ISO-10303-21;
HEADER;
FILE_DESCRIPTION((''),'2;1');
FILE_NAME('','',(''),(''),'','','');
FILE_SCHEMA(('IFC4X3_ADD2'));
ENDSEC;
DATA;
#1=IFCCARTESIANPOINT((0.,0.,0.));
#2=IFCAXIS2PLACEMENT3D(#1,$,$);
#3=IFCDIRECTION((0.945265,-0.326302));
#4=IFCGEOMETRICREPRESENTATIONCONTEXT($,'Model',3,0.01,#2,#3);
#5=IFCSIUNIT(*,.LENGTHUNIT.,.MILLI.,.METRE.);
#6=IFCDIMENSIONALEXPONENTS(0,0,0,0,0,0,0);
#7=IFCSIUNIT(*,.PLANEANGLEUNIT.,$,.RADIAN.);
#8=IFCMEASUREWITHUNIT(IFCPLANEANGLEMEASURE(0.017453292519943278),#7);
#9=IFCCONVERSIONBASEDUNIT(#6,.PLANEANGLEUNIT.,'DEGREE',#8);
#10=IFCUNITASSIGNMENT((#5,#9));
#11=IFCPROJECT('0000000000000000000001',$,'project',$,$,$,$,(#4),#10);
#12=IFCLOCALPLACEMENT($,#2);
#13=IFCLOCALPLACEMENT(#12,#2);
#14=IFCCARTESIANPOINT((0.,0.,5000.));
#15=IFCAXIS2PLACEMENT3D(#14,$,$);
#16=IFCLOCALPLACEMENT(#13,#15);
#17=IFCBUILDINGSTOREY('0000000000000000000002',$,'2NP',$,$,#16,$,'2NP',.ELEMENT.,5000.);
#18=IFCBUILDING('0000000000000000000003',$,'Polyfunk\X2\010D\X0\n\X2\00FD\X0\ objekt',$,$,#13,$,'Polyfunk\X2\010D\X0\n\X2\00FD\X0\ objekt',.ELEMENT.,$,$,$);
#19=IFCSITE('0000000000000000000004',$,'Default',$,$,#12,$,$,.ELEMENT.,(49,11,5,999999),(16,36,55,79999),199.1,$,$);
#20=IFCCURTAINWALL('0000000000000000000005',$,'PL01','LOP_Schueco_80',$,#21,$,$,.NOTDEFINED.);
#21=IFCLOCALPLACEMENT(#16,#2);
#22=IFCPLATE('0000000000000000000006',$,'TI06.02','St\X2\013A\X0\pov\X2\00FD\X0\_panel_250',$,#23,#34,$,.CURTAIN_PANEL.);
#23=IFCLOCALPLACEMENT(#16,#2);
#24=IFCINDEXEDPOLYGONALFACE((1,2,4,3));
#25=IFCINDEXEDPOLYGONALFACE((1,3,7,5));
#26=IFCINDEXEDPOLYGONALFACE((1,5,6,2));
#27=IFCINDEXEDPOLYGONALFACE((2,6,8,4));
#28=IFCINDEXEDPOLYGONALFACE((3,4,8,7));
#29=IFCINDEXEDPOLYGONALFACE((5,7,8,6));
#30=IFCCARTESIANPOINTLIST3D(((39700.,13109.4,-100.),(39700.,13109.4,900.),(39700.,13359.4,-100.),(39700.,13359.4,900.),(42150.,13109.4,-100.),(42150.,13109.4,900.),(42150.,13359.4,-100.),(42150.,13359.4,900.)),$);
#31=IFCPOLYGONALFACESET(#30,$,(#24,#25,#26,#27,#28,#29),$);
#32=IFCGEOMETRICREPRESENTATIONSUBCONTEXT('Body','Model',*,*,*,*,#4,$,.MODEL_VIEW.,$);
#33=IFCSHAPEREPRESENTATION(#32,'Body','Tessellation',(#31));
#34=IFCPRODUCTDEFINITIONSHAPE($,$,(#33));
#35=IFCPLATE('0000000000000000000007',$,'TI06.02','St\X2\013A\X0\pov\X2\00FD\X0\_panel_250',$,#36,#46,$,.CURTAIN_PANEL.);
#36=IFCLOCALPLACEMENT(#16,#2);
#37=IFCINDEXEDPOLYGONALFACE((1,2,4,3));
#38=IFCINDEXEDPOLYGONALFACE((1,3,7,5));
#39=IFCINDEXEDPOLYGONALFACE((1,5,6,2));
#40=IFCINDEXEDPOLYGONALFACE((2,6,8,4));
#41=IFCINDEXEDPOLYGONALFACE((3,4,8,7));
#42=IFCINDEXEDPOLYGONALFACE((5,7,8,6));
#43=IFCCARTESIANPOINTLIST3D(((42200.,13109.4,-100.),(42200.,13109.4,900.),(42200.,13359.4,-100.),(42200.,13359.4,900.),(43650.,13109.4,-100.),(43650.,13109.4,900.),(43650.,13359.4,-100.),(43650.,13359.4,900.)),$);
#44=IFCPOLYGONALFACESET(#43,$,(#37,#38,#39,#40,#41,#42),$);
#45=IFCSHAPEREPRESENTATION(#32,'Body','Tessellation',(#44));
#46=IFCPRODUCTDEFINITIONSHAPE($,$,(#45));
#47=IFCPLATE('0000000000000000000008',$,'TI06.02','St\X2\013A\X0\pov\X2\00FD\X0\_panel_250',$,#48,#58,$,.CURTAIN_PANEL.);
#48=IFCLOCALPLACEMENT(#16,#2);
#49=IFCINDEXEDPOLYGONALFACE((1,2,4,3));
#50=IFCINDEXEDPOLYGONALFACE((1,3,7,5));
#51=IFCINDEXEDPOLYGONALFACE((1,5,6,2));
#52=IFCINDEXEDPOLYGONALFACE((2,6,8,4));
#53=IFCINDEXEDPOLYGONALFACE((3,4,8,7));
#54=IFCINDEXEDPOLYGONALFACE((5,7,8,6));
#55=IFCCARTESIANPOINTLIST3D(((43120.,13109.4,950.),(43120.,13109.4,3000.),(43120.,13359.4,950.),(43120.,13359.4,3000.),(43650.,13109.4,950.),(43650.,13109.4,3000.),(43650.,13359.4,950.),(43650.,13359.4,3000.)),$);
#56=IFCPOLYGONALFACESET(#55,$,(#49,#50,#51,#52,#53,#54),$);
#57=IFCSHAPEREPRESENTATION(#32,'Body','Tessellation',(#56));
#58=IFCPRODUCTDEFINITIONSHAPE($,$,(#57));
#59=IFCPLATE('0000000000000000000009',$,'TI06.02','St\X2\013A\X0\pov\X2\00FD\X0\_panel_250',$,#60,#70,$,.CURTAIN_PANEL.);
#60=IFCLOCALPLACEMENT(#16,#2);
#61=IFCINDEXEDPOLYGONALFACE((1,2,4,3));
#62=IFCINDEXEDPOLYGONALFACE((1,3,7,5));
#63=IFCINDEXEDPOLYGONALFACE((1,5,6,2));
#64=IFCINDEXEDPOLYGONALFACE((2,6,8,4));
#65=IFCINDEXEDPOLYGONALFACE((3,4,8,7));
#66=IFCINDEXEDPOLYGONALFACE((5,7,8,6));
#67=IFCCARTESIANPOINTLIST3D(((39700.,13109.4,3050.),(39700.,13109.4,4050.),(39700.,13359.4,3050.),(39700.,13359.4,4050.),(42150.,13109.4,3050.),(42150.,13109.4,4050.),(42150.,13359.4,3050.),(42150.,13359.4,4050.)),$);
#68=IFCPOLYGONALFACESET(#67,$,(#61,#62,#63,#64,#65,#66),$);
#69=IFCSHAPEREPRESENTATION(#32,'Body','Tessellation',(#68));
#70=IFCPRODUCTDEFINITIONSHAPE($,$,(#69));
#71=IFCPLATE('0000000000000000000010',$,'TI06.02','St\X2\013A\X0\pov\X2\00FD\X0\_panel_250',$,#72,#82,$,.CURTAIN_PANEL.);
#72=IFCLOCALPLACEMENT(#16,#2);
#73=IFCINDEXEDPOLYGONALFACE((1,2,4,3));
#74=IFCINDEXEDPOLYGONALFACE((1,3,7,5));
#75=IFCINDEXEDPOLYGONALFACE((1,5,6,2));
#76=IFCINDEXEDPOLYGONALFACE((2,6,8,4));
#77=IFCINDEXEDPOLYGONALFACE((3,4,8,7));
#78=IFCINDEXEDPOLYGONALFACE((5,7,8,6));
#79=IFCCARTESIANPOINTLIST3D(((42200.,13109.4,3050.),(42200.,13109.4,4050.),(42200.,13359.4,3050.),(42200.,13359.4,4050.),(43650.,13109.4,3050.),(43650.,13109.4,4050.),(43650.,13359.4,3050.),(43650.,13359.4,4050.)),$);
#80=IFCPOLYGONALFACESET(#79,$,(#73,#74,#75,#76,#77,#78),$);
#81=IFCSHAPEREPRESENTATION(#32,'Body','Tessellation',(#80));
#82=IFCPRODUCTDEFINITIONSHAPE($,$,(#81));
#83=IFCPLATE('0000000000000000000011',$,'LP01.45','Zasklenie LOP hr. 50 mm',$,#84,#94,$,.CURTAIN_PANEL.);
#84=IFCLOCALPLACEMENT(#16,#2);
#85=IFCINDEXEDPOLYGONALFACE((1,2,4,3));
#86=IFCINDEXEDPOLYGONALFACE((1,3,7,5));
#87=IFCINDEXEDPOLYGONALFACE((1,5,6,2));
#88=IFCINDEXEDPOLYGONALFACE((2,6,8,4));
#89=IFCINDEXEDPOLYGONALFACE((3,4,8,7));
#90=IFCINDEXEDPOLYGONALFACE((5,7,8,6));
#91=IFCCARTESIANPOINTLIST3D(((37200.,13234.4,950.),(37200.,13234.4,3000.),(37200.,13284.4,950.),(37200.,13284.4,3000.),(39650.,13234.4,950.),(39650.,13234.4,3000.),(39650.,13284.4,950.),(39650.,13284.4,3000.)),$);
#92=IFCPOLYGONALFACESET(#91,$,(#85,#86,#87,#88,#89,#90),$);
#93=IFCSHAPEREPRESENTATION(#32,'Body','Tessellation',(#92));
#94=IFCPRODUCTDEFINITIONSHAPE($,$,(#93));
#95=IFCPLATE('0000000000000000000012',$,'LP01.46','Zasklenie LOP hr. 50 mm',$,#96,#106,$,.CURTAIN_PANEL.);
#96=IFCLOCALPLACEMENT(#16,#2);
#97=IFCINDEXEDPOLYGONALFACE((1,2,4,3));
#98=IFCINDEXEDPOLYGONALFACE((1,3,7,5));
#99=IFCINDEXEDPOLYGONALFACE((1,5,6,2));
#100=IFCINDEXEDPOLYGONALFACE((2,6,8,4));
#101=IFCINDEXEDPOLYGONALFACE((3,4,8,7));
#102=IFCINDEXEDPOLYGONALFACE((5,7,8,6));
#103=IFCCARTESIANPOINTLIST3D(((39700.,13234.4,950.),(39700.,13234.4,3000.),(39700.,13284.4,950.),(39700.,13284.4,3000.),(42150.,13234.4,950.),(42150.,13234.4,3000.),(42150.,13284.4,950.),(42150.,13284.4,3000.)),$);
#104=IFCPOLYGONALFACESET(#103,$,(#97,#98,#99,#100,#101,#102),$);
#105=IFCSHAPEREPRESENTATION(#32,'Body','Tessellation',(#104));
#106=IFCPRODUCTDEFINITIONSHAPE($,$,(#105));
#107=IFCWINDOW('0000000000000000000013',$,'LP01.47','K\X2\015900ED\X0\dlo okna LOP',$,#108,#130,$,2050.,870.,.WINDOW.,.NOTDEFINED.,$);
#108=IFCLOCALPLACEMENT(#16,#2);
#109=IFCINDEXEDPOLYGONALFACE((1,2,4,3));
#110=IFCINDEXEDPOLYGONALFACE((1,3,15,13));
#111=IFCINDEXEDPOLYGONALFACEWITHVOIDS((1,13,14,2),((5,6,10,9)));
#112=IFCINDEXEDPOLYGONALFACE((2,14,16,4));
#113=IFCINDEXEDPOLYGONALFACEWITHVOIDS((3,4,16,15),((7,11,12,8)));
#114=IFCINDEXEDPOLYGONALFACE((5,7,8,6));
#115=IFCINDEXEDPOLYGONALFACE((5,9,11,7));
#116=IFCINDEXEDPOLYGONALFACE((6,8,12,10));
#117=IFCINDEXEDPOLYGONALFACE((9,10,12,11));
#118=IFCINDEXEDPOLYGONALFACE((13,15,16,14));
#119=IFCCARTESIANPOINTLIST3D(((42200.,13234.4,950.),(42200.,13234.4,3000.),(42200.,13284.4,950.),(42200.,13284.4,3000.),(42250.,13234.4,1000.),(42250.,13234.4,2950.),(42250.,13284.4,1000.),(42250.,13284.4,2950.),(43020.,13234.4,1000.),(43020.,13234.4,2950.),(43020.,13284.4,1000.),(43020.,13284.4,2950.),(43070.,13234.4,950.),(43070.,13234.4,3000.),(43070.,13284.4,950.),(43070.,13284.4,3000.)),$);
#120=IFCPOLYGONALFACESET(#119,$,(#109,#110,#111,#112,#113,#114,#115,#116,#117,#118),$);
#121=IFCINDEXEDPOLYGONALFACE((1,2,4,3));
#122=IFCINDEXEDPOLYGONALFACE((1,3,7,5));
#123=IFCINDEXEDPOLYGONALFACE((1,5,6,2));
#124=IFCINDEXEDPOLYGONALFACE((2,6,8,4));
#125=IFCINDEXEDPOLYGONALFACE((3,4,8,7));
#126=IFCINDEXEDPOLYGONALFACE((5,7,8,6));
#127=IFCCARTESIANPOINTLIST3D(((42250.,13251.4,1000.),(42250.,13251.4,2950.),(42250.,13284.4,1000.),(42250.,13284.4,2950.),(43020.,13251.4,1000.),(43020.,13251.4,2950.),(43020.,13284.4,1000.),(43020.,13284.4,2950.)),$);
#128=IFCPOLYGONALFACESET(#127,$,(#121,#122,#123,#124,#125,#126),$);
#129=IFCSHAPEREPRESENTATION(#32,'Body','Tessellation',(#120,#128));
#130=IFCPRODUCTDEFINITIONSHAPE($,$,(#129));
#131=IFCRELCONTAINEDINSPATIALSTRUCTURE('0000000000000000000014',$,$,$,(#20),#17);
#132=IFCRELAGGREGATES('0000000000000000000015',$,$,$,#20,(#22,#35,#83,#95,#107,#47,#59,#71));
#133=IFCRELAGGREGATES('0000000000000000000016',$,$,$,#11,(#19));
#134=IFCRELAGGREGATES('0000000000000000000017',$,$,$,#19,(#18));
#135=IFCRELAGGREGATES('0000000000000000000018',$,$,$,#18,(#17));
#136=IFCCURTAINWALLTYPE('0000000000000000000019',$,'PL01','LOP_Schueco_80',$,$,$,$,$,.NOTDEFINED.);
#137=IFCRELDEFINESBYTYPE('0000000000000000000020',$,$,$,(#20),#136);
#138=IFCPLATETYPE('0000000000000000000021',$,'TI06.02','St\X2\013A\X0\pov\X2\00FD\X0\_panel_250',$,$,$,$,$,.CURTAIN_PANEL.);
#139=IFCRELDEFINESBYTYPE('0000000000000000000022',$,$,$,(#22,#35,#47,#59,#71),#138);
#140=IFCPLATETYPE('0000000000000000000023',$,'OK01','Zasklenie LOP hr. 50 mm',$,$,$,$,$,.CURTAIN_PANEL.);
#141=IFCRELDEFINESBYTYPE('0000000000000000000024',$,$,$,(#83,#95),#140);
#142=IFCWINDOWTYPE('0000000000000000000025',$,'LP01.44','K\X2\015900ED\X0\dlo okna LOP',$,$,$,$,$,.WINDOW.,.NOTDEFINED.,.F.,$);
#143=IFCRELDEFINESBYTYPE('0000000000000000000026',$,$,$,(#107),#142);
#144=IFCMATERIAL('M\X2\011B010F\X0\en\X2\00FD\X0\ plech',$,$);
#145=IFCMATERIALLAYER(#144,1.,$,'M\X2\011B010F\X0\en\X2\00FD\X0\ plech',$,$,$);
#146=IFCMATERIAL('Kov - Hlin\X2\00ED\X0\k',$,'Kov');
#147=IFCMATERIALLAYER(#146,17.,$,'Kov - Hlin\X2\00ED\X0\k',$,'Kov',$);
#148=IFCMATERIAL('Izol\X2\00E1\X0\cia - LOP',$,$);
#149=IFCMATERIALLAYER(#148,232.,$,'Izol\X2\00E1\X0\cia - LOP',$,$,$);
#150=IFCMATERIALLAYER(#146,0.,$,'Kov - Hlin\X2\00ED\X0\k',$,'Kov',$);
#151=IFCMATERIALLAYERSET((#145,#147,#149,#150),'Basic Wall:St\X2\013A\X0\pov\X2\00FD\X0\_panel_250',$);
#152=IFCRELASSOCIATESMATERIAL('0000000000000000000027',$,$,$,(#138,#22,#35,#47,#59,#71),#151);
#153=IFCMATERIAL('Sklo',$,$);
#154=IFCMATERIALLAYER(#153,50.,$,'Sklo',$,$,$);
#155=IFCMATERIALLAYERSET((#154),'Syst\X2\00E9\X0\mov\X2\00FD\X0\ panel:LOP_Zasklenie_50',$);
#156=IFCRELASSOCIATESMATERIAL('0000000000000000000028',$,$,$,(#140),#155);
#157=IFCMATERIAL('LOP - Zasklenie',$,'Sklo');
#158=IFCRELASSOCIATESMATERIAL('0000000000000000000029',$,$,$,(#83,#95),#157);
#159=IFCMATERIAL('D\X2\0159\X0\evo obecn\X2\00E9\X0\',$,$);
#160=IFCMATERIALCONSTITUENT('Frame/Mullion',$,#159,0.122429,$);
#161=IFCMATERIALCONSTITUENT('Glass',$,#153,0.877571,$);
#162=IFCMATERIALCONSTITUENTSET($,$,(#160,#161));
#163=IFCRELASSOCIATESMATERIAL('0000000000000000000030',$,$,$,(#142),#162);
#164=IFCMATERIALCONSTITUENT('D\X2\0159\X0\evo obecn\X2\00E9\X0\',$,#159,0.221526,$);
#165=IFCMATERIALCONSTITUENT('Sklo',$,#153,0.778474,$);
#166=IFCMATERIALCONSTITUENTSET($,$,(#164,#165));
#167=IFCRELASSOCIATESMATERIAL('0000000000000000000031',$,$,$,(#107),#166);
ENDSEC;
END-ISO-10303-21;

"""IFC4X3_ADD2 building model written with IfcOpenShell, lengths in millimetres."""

from ifc_helpers import new_model, entity, si_unit, converted_unit, direction, frame, frame_2d, origin, origin_2d_with_axis, place, context, subcontext, project, spatial, polyline, rectangle, outline, extrude, source, transform, mapped, material, layer, layer_set, layer_usage, constituent, constituent_set, type_object, type_shapes, element, aggregate, save


model = new_model("IFC4X3_ADD2")

# Units and contexts
model_context = context("Model", 3, precision=0.01, world=origin(), true_north=direction((0.945265, -0.326302)))
body_context = subcontext(model_context, "Body", "Model", "MODEL_VIEW")
ifc_project = project(units=[si_unit("LENGTHUNIT", "METRE", prefix="MILLI"), converted_unit("PLANEANGLEUNIT", "DEGREE", entity("IfcPlaneAngleMeasure", 0.017453292519943278), si_unit("PLANEANGLEUNIT", "RADIAN"), dimensions=[0, 0, 0, 0, 0, 0, 0])], contexts=[model_context])

# Site, building, storey
site_placement = place(None, origin())
site = spatial("IfcSite", under=ifc_project, at=site_placement, Name="Default", CompositionType="ELEMENT", RefLatitude=(49, 11, 5, 999999), RefLongitude=(16, 36, 55, 79999), RefElevation=199.1)
building_placement = place(site_placement, origin())
building = spatial("IfcBuilding", under=site, at=building_placement, Name="Polyfunkčný objekt", LongName="Polyfunkčný objekt", CompositionType="ELEMENT")
storey_placement = place(building_placement, frame((0.0, 0.0, 5000.0)))
storey = spatial("IfcBuildingStorey", under=building, at=storey_placement, Name="2NP", LongName="2NP", CompositionType="ELEMENT", Elevation=5000.0)

# Curtain wall, plates, window
curtain_wall_type = type_object("IfcCurtainWallType", Name="PL01", Description="LOP_Schueco_80", PredefinedType="NOTDEFINED")
curtain_wall_placement = place(storey_placement, frame((0.0, 0.0, -5000.0)))
curtain_wall = element("IfcCurtainWall", 1, at=curtain_wall_placement, inside=storey, type_object=curtain_wall_type, Name="PL01", Description="LOP_Schueco_80", PredefinedType="NOTDEFINED")
ifc_material_1 = material(Name="Měďený plech")
ifc_layer_1 = layer(ifc_material_1, 1.0, Name="Měďený plech")
ifc_material_2 = material(Name="Kov - Hliník", Category="Kov")
ifc_layer_2 = layer(ifc_material_2, 17.0, Name="Kov - Hliník", Category="Kov")
ifc_material_3 = material(Name="Izolácia - LOP")
ifc_layer_3 = layer(ifc_material_3, 232.0, Name="Izolácia - LOP")
ifc_layer_4 = layer(ifc_material_2, 0.0, Name="Kov - Hliník", Category="Kov")
ifc_layer_set_1 = layer_set([ifc_layer_1, ifc_layer_2, ifc_layer_3, ifc_layer_4], Name="Basic Wall:Stĺpový_panel_250")
ifc_layer_usage_1 = layer_usage(ifc_layer_set_1, "AXIS2", "NEGATIVE", 125.0)
plate_type_1 = type_object("IfcPlateType", Name="TI06.02", Description="Stĺpový_panel_250", PredefinedType="CURTAIN_PANEL", material=ifc_layer_set_1)
plate_1_placement = place(storey_placement, frame((39700.0, 13234.4, -100.0)))
plate_1 = element("IfcPlate", 2, at=plate_1_placement, type_object=plate_type_1, material=ifc_layer_usage_1, Name="TI06.02", Description="Stĺpový_panel_250", PredefinedType="CURTAIN_PANEL", context=body_context, shape_type="SweptSolid", body=[
    extrude(rectangle(XDim=250.0, YDim=2450.0, at=frame_2d((0.0, 0.0), x_axis=(1.0, 0.0))), frame((1225.0, 0.0, 0.0), z_axis=(0.0, 0.0, 1.0), x_axis=(0.0, 1.0, 0.0)), (0.0, 0.0, 1.0), 1000.0),
])
ifc_layer_usage_2 = layer_usage(ifc_layer_set_1, "AXIS2", "NEGATIVE", 125.0)
plate_2_placement = place(storey_placement, frame((42200.0, 13234.4, -100.0)))
plate_2 = element("IfcPlate", 3, at=plate_2_placement, type_object=plate_type_1, material=ifc_layer_usage_2, Name="TI06.02", Description="Stĺpový_panel_250", PredefinedType="CURTAIN_PANEL", context=body_context, shape_type="SweptSolid", body=[
    extrude(rectangle(XDim=250.0, YDim=1450.0, at=frame_2d((0.0, 0.0), x_axis=(1.0, 0.0))), frame((725.0, 0.0, 0.0), z_axis=(0.0, 0.0, 1.0), x_axis=(0.0, 1.0, 0.0)), (0.0, 0.0, 1.0), 1000.0),
])
ifc_layer_usage_3 = layer_usage(ifc_layer_set_1, "AXIS2", "NEGATIVE", 125.0)
plate_3_placement = place(storey_placement, frame((43120.0, 13234.4, 950.0)))
plate_3 = element("IfcPlate", 4, at=plate_3_placement, type_object=plate_type_1, material=ifc_layer_usage_3, Name="TI06.02", Description="Stĺpový_panel_250", PredefinedType="CURTAIN_PANEL", context=body_context, shape_type="SweptSolid", body=[
    extrude(rectangle(XDim=250.0, YDim=530.0, at=frame_2d((0.0, 0.0), x_axis=(1.0, 0.0))), frame((265.0, 0.0, 0.0), z_axis=(0.0, 0.0, 1.0), x_axis=(0.0, 1.0, 0.0)), (0.0, 0.0, 1.0), 2050.0),
])
ifc_layer_usage_4 = layer_usage(ifc_layer_set_1, "AXIS2", "NEGATIVE", 125.0)
plate_4_placement = place(storey_placement, frame((39700.0, 13234.4, 3050.0)))
plate_4 = element("IfcPlate", 5, at=plate_4_placement, type_object=plate_type_1, material=ifc_layer_usage_4, Name="TI06.02", Description="Stĺpový_panel_250", PredefinedType="CURTAIN_PANEL", context=body_context, shape_type="SweptSolid", body=[
    extrude(rectangle(XDim=250.0, YDim=2450.0, at=frame_2d((0.0, 0.0), x_axis=(1.0, 0.0))), frame((1225.0, 0.0, 0.0), z_axis=(0.0, 0.0, 1.0), x_axis=(0.0, 1.0, 0.0)), (0.0, 0.0, 1.0), 1000.0),
])
ifc_layer_usage_5 = layer_usage(ifc_layer_set_1, "AXIS2", "NEGATIVE", 125.0)
plate_5_placement = place(storey_placement, frame((42200.0, 13234.4, 3050.0)))
plate_5 = element("IfcPlate", 6, at=plate_5_placement, type_object=plate_type_1, material=ifc_layer_usage_5, Name="TI06.02", Description="Stĺpový_panel_250", PredefinedType="CURTAIN_PANEL", context=body_context, shape_type="SweptSolid", body=[
    extrude(rectangle(XDim=250.0, YDim=1450.0, at=frame_2d((0.0, 0.0), x_axis=(1.0, 0.0))), frame((725.0, 0.0, 0.0), z_axis=(0.0, 0.0, 1.0), x_axis=(0.0, 1.0, 0.0)), (0.0, 0.0, 1.0), 1000.0),
])
ifc_material_4 = material(Name="LOP - Zasklenie", Category="Sklo")
ifc_material_5 = material(Name="Sklo")
ifc_layer_5 = layer(ifc_material_5, 50.0, Name="Sklo")
ifc_layer_set_2 = layer_set([ifc_layer_5], Name="Systémový panel:LOP_Zasklenie_50")
plate_type_2 = type_object("IfcPlateType", Name="OK01", Description="Zasklenie LOP hr. 50 mm", PredefinedType="CURTAIN_PANEL", material=ifc_layer_set_2)
shared_shape_1 = source(origin(), body_context, "Body", "SweptSolid", [
    extrude(rectangle(XDim=50.0, YDim=2450.0, at=origin_2d_with_axis()), frame((0.0, 25.0, 0.0), z_axis=(0.0, 0.0, 1.0), x_axis=(0.0, 1.0, 0.0)), (0.0, 0.0, 1.0), 2050.0),
])
type_shapes(plate_type_2, [shared_shape_1])
plate_6_placement = place(curtain_wall_placement, frame((38425.0, 13234.4, 5950.0)))
plate_6 = element("IfcPlate", 7, at=plate_6_placement, type_object=plate_type_2, material=ifc_material_4, Name="LP01.45", Description="Zasklenie LOP hr. 50 mm", PredefinedType="CURTAIN_PANEL", context=body_context, shape_type="MappedRepresentation", body=[
    mapped(shared_shape_1, transform((0.0, 0.0, 0.0), scale=1.0)),
])
plate_7_placement = place(curtain_wall_placement, frame((40925.0, 13234.4, 5950.0)))
plate_7 = element("IfcPlate", 8, at=plate_7_placement, type_object=plate_type_2, material=ifc_material_4, Name="LP01.46", Description="Zasklenie LOP hr. 50 mm", PredefinedType="CURTAIN_PANEL", context=body_context, shape_type="MappedRepresentation", body=[
    mapped(shared_shape_1, transform((0.0, 0.0, 0.0), scale=1.0)),
])
ifc_material_6 = material(Name="Dřevo obecné")
ifc_constituent_1 = constituent(ifc_material_6, Name="Dřevo obecné", fraction=0.221526)
ifc_constituent_2 = constituent(ifc_material_5, Name="Sklo", fraction=0.778474)
ifc_constituent_set_1 = constituent_set(constituents=[ifc_constituent_1, ifc_constituent_2])
ifc_constituent_3 = constituent(ifc_material_6, Name="Frame/Mullion", fraction=0.122429)
ifc_constituent_4 = constituent(ifc_material_5, Name="Glass", fraction=0.877571)
ifc_constituent_set_2 = constituent_set(constituents=[ifc_constituent_3, ifc_constituent_4])
window_type = type_object("IfcWindowType", Name="LP01.44", Description="Křídlo okna LOP", ParameterTakesPrecedence=False, PartitioningType="NOTDEFINED", PredefinedType="WINDOW", material=ifc_constituent_set_2)
shared_shape_2 = source(origin(), body_context, "Body", "SweptSolid", [
    extrude(outline(polyline([(-1025.0, -435.0), (1025.0, -435.0), (1025.0, 435.0), (-1025.0, 435.0), (-1025.0, -435.0)]), holes=[polyline([(-975.0, -385.0), (-975.0, 385.0), (975.0, 385.0), (975.0, -385.0), (-975.0, -385.0)])]), frame((0.0, 0.0, 1025.0), z_axis=(0.0, 1.0, 0.0), x_axis=(0.0, 0.0, -1.0)), (0.0, 0.0, 1.0), 50.0),
    extrude(rectangle(XDim=33.0, YDim=770.0, at=origin_2d_with_axis()), frame((0.0, 33.5, 50.0), z_axis=(0.0, 0.0, 1.0), x_axis=(0.0, -1.0, 0.0)), (0.0, 0.0, 1.0), 1950.0),
])
type_shapes(window_type, [shared_shape_2])
window_placement = place(curtain_wall_placement, frame((42635.0, 13234.4, 5950.0)))
window = element("IfcWindow", 9, at=window_placement, type_object=window_type, material=ifc_constituent_set_1, Name="LP01.47", Description="Křídlo okna LOP", OverallHeight=2050.0, OverallWidth=870.0, PartitioningType="NOTDEFINED", PredefinedType="WINDOW", context=body_context, shape_type="MappedRepresentation", body=[
    mapped(shared_shape_2, transform((0.0, 0.0, 0.0), scale=1.0)),
])
aggregate(curtain_wall, [plate_1, plate_2, plate_6, plate_7, window, plate_3, plate_4, plate_5])

save(model, "model.ifc")
